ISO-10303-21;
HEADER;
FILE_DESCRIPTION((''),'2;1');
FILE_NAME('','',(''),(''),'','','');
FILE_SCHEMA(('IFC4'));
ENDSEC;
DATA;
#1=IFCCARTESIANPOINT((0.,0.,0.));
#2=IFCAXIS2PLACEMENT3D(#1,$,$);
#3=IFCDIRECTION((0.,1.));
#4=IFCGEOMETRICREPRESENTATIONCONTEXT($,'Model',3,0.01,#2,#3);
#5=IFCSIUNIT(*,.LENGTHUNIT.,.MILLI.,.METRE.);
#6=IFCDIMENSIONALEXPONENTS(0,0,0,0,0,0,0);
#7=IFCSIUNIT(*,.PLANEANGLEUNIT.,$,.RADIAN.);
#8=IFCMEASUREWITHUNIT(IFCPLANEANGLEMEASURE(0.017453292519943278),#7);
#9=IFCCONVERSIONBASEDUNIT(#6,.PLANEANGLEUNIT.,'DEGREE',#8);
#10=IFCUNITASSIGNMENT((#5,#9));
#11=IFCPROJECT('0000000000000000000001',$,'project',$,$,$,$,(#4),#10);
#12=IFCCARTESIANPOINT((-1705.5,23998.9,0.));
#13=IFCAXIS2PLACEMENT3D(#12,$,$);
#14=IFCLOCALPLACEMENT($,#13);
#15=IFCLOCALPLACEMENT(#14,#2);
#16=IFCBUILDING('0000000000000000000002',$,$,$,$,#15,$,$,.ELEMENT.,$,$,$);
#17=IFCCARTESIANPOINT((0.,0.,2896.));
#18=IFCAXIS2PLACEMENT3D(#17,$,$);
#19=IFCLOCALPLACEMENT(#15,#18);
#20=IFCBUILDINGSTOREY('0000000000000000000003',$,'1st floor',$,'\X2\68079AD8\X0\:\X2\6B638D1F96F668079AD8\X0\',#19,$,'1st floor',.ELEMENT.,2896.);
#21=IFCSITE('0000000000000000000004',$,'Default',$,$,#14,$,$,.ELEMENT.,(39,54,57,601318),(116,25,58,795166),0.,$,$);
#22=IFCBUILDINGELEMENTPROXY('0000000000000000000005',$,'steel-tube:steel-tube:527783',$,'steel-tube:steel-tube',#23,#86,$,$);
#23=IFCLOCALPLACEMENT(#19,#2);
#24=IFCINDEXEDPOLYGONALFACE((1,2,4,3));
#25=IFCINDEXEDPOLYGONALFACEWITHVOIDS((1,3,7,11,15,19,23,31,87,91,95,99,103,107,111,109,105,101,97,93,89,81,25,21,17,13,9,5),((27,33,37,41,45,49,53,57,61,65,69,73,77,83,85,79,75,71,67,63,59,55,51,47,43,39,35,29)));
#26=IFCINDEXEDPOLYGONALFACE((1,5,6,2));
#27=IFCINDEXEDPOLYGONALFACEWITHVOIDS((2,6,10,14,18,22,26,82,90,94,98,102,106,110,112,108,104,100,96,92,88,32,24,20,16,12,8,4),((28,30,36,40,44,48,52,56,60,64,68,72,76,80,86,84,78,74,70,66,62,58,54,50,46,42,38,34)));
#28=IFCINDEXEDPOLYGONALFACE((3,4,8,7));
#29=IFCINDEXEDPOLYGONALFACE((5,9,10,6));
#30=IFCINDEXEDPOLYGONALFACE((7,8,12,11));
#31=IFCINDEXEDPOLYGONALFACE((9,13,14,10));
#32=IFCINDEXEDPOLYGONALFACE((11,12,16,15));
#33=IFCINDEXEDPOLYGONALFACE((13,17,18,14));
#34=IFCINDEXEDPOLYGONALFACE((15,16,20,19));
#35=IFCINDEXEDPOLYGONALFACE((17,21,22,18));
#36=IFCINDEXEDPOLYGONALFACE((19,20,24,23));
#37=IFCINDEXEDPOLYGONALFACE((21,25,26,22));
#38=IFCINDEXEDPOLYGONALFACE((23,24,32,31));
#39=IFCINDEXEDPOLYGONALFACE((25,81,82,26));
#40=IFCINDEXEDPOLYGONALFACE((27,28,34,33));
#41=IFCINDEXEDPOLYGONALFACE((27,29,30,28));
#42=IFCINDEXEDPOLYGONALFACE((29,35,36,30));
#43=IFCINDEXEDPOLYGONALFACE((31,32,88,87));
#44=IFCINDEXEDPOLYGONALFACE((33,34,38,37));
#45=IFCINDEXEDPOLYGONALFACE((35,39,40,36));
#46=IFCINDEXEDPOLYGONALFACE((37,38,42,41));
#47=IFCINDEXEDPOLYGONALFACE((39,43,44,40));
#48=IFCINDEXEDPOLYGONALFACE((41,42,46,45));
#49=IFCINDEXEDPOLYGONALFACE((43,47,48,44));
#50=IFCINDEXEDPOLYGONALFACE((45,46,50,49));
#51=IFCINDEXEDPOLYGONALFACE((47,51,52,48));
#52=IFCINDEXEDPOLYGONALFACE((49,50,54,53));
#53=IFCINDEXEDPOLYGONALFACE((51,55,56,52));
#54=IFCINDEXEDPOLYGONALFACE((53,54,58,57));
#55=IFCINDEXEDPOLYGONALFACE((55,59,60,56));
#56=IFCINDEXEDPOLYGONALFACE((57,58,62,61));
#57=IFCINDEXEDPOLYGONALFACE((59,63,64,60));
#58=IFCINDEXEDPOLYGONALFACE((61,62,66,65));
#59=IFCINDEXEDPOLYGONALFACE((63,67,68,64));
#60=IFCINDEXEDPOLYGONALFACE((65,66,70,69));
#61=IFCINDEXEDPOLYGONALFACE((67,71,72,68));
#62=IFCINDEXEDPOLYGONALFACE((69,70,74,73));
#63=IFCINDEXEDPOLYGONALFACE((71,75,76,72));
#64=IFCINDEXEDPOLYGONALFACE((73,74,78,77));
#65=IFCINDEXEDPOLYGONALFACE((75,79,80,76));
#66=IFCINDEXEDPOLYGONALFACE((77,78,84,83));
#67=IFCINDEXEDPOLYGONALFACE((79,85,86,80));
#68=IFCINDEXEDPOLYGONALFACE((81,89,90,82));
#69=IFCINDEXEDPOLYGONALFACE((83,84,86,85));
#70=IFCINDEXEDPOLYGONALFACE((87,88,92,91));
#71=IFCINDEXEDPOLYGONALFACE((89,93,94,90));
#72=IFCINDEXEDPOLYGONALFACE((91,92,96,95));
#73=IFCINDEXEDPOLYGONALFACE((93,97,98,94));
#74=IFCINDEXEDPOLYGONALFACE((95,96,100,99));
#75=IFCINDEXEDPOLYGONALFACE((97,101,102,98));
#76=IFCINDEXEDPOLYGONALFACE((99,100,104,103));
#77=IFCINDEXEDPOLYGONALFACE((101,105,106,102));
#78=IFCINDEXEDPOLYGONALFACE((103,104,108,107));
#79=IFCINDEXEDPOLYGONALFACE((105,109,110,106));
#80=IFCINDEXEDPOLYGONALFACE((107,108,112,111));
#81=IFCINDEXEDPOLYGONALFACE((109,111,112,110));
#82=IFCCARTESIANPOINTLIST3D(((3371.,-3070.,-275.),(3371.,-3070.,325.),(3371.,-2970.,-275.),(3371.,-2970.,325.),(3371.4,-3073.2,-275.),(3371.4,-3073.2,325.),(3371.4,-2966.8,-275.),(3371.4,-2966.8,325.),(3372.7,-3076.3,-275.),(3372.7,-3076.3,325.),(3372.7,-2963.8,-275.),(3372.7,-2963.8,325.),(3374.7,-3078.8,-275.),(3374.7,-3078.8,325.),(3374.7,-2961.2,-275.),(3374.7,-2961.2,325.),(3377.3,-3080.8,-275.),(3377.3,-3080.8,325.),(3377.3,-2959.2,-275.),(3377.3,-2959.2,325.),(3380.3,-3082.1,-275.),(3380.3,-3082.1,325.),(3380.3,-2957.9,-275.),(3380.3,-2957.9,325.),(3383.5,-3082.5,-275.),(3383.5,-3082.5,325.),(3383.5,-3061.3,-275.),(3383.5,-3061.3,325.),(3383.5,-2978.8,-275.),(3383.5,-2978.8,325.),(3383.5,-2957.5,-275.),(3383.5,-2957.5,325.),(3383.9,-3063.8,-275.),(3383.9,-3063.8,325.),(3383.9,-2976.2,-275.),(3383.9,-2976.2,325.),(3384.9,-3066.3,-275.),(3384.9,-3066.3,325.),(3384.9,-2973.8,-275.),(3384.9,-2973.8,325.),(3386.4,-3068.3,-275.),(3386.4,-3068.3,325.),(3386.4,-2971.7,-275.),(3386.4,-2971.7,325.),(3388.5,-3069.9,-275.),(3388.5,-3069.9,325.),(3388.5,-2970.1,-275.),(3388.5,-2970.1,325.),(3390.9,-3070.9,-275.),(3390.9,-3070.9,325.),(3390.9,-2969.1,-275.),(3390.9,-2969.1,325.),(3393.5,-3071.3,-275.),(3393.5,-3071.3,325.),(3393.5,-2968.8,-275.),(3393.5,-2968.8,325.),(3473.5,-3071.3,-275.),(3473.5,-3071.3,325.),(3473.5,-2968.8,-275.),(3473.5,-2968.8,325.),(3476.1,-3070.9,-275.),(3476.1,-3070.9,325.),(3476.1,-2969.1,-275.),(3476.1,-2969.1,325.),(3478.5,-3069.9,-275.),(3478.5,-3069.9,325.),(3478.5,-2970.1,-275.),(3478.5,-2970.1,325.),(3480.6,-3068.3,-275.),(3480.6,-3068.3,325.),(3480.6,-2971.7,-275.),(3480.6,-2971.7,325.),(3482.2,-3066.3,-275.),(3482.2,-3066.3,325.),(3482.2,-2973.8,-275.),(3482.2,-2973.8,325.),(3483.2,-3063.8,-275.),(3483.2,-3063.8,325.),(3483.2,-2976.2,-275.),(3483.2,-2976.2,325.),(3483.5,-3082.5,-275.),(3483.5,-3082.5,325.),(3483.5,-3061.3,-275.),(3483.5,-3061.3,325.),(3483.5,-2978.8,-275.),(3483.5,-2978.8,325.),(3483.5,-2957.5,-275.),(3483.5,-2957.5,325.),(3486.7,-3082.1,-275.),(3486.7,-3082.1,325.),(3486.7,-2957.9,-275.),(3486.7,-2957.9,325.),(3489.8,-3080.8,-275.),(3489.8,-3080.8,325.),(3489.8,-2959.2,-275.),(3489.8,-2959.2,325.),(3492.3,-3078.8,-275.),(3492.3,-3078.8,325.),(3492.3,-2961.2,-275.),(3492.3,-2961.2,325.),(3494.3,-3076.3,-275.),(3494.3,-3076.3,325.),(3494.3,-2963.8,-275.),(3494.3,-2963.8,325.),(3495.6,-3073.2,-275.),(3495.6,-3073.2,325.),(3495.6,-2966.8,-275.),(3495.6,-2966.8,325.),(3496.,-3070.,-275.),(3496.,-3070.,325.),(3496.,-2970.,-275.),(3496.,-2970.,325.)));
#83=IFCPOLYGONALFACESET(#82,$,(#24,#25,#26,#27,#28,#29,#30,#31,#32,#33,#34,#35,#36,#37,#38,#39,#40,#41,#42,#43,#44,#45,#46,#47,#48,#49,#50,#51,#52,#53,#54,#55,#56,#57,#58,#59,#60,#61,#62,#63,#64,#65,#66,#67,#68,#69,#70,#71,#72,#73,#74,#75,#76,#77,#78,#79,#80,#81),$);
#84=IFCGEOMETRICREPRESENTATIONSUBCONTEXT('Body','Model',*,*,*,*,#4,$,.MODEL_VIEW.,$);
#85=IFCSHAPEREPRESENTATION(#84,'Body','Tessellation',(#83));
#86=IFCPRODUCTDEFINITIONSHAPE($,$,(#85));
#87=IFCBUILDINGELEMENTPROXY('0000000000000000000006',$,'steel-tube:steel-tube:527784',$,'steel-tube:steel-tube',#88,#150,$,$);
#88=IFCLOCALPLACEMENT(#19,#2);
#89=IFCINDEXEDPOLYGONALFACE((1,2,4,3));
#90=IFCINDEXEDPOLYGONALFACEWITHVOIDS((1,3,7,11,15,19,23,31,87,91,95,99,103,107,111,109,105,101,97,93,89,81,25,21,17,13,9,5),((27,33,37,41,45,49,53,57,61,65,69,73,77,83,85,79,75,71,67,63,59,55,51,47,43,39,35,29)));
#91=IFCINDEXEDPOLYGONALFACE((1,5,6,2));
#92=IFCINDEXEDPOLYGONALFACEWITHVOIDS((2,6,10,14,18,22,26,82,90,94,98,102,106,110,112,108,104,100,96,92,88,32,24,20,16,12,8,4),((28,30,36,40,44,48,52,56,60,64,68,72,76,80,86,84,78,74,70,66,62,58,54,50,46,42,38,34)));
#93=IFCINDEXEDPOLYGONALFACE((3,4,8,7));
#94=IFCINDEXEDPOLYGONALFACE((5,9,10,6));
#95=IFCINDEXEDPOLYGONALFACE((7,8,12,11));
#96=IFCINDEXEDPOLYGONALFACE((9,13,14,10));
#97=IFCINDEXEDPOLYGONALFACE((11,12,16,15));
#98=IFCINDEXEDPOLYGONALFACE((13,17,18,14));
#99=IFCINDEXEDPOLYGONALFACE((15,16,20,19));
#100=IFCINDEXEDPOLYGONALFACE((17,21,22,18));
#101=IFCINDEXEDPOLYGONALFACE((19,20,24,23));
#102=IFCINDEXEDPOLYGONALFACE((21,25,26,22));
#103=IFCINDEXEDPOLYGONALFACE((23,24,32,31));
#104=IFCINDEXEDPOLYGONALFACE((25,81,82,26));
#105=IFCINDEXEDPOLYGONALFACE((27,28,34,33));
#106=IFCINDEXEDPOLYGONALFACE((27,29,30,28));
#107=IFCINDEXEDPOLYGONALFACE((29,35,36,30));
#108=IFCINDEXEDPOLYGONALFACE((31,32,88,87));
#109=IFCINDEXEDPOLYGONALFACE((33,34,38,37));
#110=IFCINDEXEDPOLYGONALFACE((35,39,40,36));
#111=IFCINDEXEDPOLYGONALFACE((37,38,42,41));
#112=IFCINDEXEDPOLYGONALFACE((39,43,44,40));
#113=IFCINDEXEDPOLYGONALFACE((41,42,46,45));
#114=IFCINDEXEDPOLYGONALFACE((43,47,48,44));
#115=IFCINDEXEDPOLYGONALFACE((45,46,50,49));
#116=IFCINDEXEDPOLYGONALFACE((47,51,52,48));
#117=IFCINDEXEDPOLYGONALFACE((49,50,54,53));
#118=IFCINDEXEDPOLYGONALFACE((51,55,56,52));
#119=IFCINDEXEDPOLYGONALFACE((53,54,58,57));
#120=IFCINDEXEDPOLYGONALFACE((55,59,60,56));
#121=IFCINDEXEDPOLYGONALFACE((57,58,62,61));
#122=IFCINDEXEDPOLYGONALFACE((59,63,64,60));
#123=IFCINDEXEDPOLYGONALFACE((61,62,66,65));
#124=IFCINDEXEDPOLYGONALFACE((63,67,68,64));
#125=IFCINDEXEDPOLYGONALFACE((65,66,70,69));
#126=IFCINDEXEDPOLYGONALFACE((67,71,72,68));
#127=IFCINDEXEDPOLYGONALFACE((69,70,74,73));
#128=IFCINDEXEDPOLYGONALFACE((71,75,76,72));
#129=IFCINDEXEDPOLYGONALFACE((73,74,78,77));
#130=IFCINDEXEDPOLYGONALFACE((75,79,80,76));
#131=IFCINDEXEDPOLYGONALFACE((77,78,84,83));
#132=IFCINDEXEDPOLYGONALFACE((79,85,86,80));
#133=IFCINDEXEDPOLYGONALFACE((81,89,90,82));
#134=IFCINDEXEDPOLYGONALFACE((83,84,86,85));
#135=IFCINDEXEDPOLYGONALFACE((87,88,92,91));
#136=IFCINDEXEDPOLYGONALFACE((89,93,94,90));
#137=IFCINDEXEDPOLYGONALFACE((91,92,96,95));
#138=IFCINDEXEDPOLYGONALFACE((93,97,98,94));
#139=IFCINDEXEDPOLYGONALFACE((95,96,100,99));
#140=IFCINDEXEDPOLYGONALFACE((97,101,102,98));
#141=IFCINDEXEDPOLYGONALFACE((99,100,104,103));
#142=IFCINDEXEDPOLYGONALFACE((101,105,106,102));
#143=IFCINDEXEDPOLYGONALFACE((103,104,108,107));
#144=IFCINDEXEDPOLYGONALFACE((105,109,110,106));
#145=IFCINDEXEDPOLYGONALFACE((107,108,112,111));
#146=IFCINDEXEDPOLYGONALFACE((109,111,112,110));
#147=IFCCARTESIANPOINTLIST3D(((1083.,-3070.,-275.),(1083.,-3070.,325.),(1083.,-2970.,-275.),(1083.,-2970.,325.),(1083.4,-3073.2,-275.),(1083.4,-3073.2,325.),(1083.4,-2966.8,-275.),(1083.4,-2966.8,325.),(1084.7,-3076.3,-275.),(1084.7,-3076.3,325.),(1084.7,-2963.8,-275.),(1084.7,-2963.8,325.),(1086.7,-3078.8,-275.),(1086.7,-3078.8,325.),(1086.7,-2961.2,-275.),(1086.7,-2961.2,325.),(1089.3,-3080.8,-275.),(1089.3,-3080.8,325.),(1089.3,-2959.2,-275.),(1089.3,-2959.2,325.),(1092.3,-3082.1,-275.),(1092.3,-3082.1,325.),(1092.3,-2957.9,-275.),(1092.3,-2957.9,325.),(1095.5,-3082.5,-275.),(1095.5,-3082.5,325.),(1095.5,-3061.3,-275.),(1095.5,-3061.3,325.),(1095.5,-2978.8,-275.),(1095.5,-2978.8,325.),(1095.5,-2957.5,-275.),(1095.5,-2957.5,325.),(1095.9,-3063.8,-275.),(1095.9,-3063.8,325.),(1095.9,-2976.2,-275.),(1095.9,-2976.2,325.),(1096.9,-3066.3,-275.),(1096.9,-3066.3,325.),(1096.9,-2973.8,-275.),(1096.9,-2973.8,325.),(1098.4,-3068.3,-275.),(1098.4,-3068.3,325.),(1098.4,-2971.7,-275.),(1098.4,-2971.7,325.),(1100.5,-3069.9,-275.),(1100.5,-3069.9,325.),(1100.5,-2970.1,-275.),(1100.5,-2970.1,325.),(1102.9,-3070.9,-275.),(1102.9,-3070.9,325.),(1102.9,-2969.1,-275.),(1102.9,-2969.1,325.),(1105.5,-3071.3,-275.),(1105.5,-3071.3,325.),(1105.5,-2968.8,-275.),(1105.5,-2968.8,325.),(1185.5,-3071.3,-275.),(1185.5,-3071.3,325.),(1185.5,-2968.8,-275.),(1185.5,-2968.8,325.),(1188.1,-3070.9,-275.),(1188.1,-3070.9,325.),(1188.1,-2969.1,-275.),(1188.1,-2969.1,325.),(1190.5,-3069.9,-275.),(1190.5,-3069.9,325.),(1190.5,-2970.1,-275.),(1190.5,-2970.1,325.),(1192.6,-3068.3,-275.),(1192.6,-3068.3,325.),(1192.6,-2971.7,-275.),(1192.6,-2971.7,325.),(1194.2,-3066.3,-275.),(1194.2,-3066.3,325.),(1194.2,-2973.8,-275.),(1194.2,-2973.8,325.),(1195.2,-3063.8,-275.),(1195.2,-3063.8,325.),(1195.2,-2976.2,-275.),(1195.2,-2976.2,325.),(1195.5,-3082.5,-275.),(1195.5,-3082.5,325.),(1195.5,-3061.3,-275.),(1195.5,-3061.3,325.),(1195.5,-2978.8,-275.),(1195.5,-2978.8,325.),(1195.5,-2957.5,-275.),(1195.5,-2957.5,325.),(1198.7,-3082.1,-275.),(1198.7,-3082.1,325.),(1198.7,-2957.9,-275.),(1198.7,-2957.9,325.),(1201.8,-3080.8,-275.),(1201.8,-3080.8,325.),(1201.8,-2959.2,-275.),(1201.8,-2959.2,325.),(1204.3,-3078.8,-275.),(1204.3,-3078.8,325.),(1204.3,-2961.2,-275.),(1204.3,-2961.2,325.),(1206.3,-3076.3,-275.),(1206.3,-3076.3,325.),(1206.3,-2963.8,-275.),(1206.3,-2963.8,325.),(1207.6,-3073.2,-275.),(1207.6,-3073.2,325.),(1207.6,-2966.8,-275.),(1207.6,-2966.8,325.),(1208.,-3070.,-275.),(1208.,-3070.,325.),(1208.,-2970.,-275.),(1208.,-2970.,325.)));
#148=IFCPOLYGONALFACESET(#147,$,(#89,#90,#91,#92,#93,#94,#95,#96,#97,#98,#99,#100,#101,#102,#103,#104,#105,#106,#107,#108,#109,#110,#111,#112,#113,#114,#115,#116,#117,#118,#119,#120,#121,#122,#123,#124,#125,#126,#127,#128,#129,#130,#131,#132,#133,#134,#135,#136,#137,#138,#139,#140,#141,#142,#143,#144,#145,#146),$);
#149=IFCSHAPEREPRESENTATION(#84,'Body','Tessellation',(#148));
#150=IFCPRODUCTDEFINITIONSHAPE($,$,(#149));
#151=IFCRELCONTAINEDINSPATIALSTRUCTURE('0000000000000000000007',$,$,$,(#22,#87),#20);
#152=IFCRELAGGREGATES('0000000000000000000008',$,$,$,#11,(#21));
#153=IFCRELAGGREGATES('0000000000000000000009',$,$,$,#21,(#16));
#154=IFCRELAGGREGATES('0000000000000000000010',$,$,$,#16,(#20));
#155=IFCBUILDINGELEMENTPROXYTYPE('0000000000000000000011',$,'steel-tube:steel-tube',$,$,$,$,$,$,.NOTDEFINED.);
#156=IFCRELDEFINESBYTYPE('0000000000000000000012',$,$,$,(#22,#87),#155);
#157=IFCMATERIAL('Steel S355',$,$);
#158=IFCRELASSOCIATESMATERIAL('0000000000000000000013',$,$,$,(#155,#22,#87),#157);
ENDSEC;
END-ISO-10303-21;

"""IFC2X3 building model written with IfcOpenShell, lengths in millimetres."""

from ifc_helpers import new_model, entity, si_unit, converted_unit, direction, frame, frame_2d, origin, place, context, subcontext, project, spatial, polyline, circle_curve, parameter, trimmed, segment, composite_curve, outline, extrude, source, transform, mapped, material, type_object, type_shapes, element, save


model = new_model("IFC2X3")

# Units and contexts
model_context = context("Model", 3, precision=0.01, world=origin(), true_north=direction((0.0, 1.0)))
body_context = subcontext(model_context, "Body", "Model", "MODEL_VIEW")
ifc_project = project(units=[si_unit("LENGTHUNIT", "METRE", prefix="MILLI"), converted_unit("PLANEANGLEUNIT", "DEGREE", entity("IfcPlaneAngleMeasure", 0.017453292519943278), si_unit("PLANEANGLEUNIT", "RADIAN"), dimensions=[0, 0, 0, 0, 0, 0, 0])], contexts=[model_context])

# Site, building, storey
site_placement = place(None, frame((-1705.5, 23998.9, 0.0)))
site = spatial("IfcSite", under=ifc_project, at=site_placement, Name="Default", CompositionType="ELEMENT", RefLatitude=(39, 54, 57, 601318), RefLongitude=(116, 25, 58, 795166), RefElevation=0.0)
building_placement = place(site_placement, origin())
building = spatial("IfcBuilding", under=site, at=building_placement, CompositionType="ELEMENT")
storey_placement = place(building_placement, frame((0.0, 0.0, 2896.0)))
storey = spatial("IfcBuildingStorey", under=building, at=storey_placement, Name="1st floor", ObjectType="标高:正负零标高", LongName="1st floor", CompositionType="ELEMENT", Elevation=2896.0)

# Shared definitions
ifc_material_1 = material(Name="Steel S355")

# Building element proxies
building_element_proxy_type_1 = type_object("IfcBuildingElementProxyType", Name="steel-tube:steel-tube", PredefinedType="NOTDEFINED", material=ifc_material_1)
shared_shape_1 = source(origin(), body_context, "Body", "SweptSolid", [
    extrude(outline(composite_curve([segment(trimmed(circle_curve(frame_2d((50.0, -50.0), x_axis=(1.0, 0.0)), 12.5), [parameter(270.0)], [parameter(0.0)], True, "PARAMETER"), True, "CONTINUOUS"), segment(polyline([(62.5, -50.0), (62.5, 50.0)]), True, "CONTINUOUS"), segment(trimmed(circle_curve(frame_2d((50.0, 50.0), x_axis=(1.0, 0.0)), 12.5), [parameter(0.0)], [parameter(90.0)], True, "PARAMETER"), True, "CONTINUOUS"), segment(polyline([(50.0, 62.5), (-50.0, 62.5)]), True, "CONTINUOUS"), segment(trimmed(circle_curve(frame_2d((-50.0, 50.0), x_axis=(1.0, 0.0)), 12.5), [parameter(90.0)], [parameter(180.0)], True, "PARAMETER"), True, "CONTINUOUS"), segment(polyline([(-62.5, 50.0), (-62.5, -50.0)]), True, "CONTINUOUS"), segment(trimmed(circle_curve(frame_2d((-50.0, -50.0), x_axis=(1.0, 0.0)), 12.5), [parameter(180.0)], [parameter(270.0)], True, "PARAMETER"), True, "CONTINUOUS"), segment(polyline([(-50.0, -62.5), (50.0, -62.5)]), True, "CONTINUOUS")], self_intersect=False), holes=[composite_curve([segment(trimmed(circle_curve(frame_2d((-41.2, 40.0), x_axis=(1.0, 0.0)), 10.0), [parameter(90.0)], [parameter(180.0)], True, "PARAMETER"), False, "CONTINUOUS"), segment(polyline([(-41.3, 50.0), (41.2, 50.0)]), True, "CONTINUOUS"), segment(trimmed(circle_curve(frame_2d((41.2, 40.0), x_axis=(1.0, 0.0)), 10.0), [parameter(0.0)], [parameter(90.0)], True, "PARAMETER"), False, "CONTINUOUS"), segment(polyline([(51.2, 40.0), (51.2, -40.0)]), True, "CONTINUOUS"), segment(trimmed(circle_curve(frame_2d((41.2, -40.0), x_axis=(1.0, 0.0)), 10.0), [parameter(270.0)], [parameter(360.0)], True, "PARAMETER"), False, "CONTINUOUS"), segment(polyline([(41.2, -50.0), (-41.3, -50.0)]), True, "CONTINUOUS"), segment(trimmed(circle_curve(frame_2d((-41.3, -40.0), x_axis=(1.0, 0.0)), 10.0), [parameter(180.0)], [parameter(270.0)], True, "PARAMETER"), False, "CONTINUOUS"), segment(polyline([(-51.3, -40.0), (-51.3, 40.0)]), True, "CONTINUOUS")], self_intersect=False)]), frame((62.5, 62.5, -175.0)), (0.0, 0.0, 1.0), 600.0),
])
type_shapes(building_element_proxy_type_1, [shared_shape_1])
for number, where, z_axis, x_axis, name in (
    (1, (3371.0, -2957.5, -100.0), (0.0, 0.0, 1.0), (0.0, -1.0, 0.0), "steel-tube:steel-tube:527783"),
    (2, (1083.0, -2957.5, -100.0), (0.0, 0.0, 1.0), (0.0, -1.0, 0.0), "steel-tube:steel-tube:527784"),
):
    element("IfcBuildingElementProxy", number, at=place(storey_placement, frame(where, z_axis=z_axis, x_axis=x_axis)), inside=storey, type_object=building_element_proxy_type_1, material=ifc_material_1, Name=name, ObjectType="steel-tube:steel-tube", context=body_context, shape_type="MappedRepresentation", body=[
        mapped(shared_shape_1, transform((0.0, 0.0, 0.0), scale=1.0)),
    ])

save(model, "model.ifc")
